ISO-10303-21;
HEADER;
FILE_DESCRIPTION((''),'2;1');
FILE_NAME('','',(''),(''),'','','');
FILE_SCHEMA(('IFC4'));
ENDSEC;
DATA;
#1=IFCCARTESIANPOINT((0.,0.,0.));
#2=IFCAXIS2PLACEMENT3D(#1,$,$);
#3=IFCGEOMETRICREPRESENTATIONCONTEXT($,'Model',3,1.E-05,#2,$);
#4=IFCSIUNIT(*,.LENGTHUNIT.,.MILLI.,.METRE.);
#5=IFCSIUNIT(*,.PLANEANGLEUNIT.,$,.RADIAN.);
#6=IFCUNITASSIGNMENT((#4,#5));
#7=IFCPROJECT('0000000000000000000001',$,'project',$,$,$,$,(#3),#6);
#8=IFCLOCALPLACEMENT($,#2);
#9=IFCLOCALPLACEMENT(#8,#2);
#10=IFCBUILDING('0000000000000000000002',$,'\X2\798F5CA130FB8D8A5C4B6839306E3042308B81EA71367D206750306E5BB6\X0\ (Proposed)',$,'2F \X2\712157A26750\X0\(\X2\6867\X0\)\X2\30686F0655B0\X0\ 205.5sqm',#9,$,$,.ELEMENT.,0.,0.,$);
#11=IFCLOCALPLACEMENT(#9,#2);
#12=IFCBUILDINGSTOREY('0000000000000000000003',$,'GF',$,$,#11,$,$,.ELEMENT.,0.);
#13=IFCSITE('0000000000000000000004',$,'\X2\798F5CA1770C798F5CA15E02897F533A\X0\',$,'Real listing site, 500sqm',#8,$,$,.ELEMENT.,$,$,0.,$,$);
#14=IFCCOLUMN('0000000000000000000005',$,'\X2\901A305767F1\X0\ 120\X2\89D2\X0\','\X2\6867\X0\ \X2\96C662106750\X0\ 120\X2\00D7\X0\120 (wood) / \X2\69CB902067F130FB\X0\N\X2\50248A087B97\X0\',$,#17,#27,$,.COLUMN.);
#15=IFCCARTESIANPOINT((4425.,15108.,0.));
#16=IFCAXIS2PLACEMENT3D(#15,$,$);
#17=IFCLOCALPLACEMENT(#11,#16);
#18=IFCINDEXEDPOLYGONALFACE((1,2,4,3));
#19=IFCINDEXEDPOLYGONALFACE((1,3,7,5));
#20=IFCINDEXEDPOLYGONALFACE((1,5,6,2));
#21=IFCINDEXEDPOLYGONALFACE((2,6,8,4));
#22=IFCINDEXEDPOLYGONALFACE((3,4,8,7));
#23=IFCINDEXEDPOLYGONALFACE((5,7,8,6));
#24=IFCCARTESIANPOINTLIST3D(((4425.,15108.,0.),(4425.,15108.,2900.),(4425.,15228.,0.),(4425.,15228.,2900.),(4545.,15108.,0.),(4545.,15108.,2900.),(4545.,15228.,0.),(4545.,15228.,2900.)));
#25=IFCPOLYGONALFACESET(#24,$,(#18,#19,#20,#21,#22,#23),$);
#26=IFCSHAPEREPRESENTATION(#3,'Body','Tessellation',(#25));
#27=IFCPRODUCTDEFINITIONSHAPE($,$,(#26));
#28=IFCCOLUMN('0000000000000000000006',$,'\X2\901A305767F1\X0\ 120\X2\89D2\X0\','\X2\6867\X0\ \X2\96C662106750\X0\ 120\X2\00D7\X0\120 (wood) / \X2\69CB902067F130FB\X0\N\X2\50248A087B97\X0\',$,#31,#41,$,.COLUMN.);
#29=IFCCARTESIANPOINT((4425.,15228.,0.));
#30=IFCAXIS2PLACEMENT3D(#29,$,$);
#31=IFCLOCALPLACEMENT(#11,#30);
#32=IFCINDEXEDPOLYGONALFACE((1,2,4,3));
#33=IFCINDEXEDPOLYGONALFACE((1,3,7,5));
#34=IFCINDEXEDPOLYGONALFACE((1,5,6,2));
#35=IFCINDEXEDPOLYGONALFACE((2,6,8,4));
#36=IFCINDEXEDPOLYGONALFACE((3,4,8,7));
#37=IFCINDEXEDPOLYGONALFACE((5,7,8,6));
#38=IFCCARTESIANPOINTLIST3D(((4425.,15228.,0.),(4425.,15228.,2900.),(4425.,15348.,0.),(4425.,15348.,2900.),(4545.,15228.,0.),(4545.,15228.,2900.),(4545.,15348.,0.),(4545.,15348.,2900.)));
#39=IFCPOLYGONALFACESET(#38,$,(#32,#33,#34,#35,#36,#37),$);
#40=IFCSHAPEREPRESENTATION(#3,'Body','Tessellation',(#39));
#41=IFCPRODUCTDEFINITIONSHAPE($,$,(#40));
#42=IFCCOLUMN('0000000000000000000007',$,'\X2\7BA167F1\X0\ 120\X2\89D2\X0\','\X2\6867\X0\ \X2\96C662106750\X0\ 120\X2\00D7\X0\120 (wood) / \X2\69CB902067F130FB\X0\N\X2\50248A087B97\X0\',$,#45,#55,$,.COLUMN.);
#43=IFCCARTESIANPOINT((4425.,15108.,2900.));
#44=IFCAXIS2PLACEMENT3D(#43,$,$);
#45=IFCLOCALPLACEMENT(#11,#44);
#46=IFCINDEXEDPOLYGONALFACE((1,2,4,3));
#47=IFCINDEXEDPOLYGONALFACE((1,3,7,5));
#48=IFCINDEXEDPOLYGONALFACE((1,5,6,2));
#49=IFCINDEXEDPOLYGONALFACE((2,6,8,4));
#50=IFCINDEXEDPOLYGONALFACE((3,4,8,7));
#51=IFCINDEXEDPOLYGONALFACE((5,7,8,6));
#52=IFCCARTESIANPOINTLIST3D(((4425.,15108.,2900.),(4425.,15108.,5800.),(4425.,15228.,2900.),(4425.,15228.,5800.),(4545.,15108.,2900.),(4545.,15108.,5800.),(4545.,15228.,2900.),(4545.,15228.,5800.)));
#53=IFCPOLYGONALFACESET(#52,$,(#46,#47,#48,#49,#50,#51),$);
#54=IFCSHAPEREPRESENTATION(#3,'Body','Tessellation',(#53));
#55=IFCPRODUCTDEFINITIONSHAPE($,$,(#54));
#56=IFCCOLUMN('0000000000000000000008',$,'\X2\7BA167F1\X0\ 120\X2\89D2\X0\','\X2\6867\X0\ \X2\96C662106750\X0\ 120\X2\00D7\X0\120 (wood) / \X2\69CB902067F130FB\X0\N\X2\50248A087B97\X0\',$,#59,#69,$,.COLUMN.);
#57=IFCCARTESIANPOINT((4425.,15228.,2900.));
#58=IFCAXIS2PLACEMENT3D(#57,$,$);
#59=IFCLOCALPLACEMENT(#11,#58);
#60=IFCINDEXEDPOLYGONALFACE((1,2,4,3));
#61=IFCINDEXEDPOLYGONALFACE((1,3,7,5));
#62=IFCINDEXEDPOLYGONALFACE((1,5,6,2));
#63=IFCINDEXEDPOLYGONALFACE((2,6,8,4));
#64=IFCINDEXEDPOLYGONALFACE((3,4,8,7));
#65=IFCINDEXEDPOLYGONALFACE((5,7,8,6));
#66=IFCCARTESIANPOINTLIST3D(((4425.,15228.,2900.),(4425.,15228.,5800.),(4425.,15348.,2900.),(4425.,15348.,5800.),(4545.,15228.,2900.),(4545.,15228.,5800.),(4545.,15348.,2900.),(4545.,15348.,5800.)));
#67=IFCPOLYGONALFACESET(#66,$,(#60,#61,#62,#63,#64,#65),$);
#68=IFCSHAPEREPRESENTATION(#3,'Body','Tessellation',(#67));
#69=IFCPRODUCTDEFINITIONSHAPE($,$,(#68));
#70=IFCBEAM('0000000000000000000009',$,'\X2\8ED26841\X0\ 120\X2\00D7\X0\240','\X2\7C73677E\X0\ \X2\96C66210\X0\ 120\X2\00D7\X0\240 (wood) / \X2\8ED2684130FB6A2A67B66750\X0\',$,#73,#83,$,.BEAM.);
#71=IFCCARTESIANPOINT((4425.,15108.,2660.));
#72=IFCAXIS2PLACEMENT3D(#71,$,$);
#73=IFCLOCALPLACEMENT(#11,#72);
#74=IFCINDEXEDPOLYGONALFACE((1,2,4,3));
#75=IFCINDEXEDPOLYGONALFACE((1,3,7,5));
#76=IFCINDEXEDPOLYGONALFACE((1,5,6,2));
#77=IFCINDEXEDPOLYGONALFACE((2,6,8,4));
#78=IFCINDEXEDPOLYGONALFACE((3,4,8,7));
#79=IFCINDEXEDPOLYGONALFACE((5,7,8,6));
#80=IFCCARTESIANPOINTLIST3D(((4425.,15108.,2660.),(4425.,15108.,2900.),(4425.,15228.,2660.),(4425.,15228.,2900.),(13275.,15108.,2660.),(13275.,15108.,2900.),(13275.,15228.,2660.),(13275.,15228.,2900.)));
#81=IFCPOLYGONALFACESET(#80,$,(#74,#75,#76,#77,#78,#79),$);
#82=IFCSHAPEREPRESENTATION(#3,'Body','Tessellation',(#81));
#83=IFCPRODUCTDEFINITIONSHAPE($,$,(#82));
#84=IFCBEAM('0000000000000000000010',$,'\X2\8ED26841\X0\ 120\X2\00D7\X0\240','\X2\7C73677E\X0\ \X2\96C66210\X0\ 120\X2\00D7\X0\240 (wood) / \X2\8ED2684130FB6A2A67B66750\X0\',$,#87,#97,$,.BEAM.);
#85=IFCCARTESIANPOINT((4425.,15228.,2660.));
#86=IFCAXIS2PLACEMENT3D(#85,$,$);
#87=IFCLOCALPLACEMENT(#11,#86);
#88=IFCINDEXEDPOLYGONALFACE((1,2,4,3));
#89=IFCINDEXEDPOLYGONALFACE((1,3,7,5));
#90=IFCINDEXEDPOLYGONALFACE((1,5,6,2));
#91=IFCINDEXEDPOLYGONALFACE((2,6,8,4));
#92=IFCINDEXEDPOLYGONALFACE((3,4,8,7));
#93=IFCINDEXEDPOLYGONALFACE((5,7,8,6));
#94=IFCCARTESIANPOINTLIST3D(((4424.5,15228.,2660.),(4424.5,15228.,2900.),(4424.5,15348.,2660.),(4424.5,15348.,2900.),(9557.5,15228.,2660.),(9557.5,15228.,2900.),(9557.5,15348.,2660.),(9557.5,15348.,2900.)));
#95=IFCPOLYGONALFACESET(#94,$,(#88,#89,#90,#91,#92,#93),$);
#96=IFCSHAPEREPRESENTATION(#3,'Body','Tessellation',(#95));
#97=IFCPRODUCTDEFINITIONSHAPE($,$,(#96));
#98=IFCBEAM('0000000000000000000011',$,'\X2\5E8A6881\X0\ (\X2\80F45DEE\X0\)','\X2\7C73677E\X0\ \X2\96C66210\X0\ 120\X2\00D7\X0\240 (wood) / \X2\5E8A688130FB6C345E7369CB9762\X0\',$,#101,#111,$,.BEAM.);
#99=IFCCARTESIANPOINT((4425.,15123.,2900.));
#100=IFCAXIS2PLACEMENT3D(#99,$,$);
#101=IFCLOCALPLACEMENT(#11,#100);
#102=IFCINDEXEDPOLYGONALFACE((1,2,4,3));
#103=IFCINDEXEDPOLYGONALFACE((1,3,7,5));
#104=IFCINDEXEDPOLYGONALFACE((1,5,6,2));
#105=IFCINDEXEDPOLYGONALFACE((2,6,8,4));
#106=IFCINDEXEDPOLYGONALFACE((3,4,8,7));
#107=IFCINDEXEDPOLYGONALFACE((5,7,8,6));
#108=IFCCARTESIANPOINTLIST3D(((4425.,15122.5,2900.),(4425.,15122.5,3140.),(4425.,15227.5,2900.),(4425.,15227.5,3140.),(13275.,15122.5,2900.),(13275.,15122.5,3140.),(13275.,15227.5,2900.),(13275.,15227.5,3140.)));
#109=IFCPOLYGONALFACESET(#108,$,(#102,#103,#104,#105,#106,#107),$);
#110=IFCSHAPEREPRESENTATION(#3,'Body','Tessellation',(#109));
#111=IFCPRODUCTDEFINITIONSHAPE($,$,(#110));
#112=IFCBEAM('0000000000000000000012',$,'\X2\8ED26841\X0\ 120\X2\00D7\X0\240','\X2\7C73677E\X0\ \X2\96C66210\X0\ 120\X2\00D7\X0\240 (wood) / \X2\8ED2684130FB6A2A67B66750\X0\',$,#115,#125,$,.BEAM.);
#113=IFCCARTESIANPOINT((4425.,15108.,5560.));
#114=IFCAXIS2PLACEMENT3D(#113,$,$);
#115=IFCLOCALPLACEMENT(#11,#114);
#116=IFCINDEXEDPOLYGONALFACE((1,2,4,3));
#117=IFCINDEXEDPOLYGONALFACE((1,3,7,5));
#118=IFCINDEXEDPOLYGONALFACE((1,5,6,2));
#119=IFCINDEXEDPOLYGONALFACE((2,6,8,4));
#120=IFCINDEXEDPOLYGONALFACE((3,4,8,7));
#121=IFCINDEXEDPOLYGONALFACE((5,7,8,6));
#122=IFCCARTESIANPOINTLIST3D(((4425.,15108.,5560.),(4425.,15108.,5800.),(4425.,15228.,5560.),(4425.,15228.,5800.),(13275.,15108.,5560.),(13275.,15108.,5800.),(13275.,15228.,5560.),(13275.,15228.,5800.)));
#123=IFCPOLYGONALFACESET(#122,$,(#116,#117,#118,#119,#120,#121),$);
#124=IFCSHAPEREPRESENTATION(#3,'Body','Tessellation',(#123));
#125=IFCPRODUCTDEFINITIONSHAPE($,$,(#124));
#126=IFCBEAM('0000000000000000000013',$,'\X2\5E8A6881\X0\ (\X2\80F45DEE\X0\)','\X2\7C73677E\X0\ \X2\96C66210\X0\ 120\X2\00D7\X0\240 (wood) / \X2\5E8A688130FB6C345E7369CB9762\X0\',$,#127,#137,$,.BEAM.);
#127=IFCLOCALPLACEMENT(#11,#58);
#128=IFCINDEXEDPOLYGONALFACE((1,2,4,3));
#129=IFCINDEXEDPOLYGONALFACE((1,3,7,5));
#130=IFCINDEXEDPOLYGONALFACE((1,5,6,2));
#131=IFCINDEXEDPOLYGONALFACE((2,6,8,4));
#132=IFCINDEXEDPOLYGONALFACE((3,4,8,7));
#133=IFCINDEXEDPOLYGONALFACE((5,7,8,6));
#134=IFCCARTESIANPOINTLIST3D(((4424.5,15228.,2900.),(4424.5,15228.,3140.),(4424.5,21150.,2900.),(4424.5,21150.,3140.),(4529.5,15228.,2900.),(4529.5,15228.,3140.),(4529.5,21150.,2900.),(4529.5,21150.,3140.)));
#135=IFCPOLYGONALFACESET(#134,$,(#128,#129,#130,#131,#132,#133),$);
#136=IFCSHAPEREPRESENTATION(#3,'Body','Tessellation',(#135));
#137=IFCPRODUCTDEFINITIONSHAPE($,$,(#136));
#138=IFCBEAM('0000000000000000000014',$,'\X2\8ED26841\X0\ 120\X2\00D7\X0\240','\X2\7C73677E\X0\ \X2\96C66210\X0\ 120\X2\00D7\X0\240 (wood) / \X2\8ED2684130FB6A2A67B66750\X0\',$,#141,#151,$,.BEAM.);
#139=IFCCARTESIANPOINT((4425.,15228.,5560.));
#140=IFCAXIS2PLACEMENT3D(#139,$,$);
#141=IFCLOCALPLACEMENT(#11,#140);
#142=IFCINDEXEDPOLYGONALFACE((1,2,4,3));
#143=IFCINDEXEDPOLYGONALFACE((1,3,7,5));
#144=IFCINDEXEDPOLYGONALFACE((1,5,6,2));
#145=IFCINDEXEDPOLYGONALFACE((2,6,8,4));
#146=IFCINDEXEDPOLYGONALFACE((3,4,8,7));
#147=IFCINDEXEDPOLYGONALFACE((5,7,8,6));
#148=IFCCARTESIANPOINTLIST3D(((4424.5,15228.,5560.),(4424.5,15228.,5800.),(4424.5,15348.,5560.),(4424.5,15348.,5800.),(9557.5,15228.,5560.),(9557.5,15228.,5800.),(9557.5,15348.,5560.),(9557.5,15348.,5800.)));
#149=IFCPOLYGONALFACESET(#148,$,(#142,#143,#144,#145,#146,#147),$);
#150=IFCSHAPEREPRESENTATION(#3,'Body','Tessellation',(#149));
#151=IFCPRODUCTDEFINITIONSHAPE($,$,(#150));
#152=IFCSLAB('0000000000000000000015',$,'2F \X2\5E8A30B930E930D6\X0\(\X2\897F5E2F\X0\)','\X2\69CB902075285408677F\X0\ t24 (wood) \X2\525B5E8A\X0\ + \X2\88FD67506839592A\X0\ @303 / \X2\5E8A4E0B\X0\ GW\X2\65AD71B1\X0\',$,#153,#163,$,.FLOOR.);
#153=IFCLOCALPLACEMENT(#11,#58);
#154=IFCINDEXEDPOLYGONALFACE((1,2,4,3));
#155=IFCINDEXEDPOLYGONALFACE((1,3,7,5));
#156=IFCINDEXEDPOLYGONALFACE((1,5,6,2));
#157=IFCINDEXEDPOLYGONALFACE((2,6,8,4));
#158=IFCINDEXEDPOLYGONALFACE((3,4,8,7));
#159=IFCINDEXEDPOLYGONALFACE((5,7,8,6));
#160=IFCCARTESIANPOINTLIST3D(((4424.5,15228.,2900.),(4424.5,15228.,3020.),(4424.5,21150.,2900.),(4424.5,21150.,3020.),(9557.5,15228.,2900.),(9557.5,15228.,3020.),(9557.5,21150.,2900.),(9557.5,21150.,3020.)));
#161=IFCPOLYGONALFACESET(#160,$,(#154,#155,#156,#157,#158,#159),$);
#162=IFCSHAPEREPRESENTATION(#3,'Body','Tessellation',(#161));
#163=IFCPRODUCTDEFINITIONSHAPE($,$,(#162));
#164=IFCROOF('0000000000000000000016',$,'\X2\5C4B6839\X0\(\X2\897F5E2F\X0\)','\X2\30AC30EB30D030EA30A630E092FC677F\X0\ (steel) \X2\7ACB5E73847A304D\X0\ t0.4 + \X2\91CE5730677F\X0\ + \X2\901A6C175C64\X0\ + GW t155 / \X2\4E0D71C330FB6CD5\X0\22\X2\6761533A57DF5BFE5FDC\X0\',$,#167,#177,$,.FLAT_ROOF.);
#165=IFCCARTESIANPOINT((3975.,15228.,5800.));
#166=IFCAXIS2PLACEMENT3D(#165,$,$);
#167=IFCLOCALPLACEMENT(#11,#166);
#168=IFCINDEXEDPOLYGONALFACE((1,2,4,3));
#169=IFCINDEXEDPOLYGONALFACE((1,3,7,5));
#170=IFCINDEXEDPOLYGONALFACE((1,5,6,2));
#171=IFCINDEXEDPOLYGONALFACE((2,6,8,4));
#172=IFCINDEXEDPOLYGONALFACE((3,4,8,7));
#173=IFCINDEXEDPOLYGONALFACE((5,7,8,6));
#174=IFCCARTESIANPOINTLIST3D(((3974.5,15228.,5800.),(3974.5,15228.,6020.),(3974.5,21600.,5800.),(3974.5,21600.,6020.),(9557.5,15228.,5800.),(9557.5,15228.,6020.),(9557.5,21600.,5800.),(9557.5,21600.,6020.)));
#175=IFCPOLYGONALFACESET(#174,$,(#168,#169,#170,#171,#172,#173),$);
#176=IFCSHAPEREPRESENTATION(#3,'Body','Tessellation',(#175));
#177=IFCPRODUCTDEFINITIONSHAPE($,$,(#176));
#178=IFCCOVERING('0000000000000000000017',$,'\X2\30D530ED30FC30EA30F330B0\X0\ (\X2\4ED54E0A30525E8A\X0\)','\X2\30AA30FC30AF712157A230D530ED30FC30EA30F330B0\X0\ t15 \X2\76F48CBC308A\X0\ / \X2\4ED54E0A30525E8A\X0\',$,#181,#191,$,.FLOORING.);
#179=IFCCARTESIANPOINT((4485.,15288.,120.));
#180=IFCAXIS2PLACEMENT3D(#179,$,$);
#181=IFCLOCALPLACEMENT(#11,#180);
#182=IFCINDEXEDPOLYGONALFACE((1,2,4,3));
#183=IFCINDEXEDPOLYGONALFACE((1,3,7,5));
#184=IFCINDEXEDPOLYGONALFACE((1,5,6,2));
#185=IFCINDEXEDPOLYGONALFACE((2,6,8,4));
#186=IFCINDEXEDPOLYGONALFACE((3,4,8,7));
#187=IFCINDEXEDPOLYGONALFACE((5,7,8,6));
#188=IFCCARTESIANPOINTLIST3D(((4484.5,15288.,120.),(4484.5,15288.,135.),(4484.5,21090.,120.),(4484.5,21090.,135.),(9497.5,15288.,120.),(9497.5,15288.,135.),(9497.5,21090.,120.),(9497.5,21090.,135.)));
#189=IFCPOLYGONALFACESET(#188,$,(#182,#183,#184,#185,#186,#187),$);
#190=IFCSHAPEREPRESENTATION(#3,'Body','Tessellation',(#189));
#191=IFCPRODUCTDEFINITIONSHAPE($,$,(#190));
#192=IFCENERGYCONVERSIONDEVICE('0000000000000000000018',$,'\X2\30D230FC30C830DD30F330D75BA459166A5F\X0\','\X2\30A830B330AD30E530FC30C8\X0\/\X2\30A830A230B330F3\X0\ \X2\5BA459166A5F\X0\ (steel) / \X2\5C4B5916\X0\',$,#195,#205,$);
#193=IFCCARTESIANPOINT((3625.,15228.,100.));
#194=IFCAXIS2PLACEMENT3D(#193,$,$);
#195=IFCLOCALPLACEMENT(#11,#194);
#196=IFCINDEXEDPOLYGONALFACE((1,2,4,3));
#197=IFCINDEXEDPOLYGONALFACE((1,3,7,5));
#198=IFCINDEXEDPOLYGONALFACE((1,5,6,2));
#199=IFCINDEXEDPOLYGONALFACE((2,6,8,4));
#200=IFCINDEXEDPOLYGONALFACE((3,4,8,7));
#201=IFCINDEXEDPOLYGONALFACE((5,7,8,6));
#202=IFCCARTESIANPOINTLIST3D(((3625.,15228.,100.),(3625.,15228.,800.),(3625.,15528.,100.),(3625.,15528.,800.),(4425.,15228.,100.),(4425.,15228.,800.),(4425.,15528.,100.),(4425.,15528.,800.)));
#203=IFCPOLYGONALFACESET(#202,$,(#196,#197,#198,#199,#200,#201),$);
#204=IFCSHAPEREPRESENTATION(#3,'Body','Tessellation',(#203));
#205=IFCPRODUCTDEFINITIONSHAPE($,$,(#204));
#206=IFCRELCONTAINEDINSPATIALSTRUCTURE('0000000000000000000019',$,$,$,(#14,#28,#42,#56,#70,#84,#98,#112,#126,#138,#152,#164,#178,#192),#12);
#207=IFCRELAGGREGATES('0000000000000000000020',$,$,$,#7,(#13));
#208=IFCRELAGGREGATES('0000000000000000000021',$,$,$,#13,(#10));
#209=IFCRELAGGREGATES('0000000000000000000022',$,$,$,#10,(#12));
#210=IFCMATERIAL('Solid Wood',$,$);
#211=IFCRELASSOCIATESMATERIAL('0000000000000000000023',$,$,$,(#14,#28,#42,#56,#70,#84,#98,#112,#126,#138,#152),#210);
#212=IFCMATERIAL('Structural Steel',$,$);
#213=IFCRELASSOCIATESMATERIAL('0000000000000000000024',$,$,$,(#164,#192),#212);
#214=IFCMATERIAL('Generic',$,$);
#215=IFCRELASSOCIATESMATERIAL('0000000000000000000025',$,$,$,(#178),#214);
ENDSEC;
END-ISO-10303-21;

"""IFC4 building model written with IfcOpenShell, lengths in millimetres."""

from ifc_helpers import new_model, si_unit, frame, frame_2d, origin, place, context, project, spatial, rectangle, extrude, material, element, save


model = new_model("IFC4")

# Units and contexts
model_context = context("Model", 3, precision=1e-05, world=origin())
ifc_project = project(units=[si_unit("LENGTHUNIT", "METRE", prefix="MILLI"), si_unit("PLANEANGLEUNIT", "RADIAN")], contexts=[model_context])

# Site, building, storey
site_placement = place(None, origin())
site = spatial("IfcSite", under=ifc_project, at=site_placement, Name="福岡県福岡市西区", ObjectType="Real listing site, 500sqm", CompositionType="ELEMENT", RefElevation=0.0)
building_placement = place(site_placement, origin())
building = spatial("IfcBuilding", under=site, at=building_placement, Name="福岡・越屋根のある自然素材の家 (Proposed)", ObjectType="2F 無垢材(桧)と漆喰 205.5sqm", CompositionType="ELEMENT", ElevationOfRefHeight=0.0, ElevationOfTerrain=0.0)
storey_placement = place(building_placement, origin())
storey = spatial("IfcBuildingStorey", under=building, at=storey_placement, Name="GF", CompositionType="ELEMENT", Elevation=0.0)

# Columns
ifc_material_1 = material(Name="Solid Wood")
column_1_placement = place(storey_placement, frame((4425.0, 15108.0, 0.0)))
element("IfcColumn", 1, at=column_1_placement, inside=storey, material=ifc_material_1, Name="通し柱 120角", Description="桧 集成材 120×120 (wood) / 構造柱・N値計算", PredefinedType="COLUMN", context=model_context, shape_type="SweptSolid", body=[
    extrude(rectangle(XDim=120.0, YDim=120.0, at=frame_2d((60.0, 60.0))), frame((4425.0, 15108.0, 0.0)), (0.0, 0.0, 1.0), 2900.0),
])
column_2_placement = place(storey_placement, frame((4425.0, 15228.0, 0.0)))
element("IfcColumn", 2, at=column_2_placement, inside=storey, material=ifc_material_1, Name="通し柱 120角", Description="桧 集成材 120×120 (wood) / 構造柱・N値計算", PredefinedType="COLUMN", context=model_context, shape_type="SweptSolid", body=[
    extrude(rectangle(XDim=120.0, YDim=120.0, at=frame_2d((60.0, 60.0))), frame((4425.0, 15228.0, 0.0)), (0.0, 0.0, 1.0), 2900.0),
])
column_3_placement = place(storey_placement, frame((4425.0, 15108.0, 2900.0)))
element("IfcColumn", 3, at=column_3_placement, inside=storey, material=ifc_material_1, Name="管柱 120角", Description="桧 集成材 120×120 (wood) / 構造柱・N値計算", PredefinedType="COLUMN", context=model_context, shape_type="SweptSolid", body=[
    extrude(rectangle(XDim=120.0, YDim=120.0, at=frame_2d((60.0, 60.0))), frame((4425.0, 15108.0, 2900.0)), (0.0, 0.0, 1.0), 2900.0),
])
column_4_placement = place(storey_placement, frame((4425.0, 15228.0, 2900.0)))
element("IfcColumn", 4, at=column_4_placement, inside=storey, material=ifc_material_1, Name="管柱 120角", Description="桧 集成材 120×120 (wood) / 構造柱・N値計算", PredefinedType="COLUMN", context=model_context, shape_type="SweptSolid", body=[
    extrude(rectangle(XDim=120.0, YDim=120.0, at=frame_2d((60.0, 60.0))), frame((4425.0, 15228.0, 2900.0)), (0.0, 0.0, 1.0), 2900.0),
])

# Beams
beam_1_placement = place(storey_placement, frame((4425.0, 15108.0, 2660.0)))
element("IfcBeam", 5, at=beam_1_placement, inside=storey, material=ifc_material_1, Name="軒桁 120×240", Description="米松 集成 120×240 (wood) / 軒桁・横架材", PredefinedType="BEAM", context=model_context, shape_type="SweptSolid", body=[
    extrude(rectangle(XDim=8850.0, YDim=120.0, at=frame_2d((4425.0, 60.0))), frame((4425.0, 15108.0, 2660.0)), (0.0, 0.0, 1.0), 240.0),
])
beam_2_placement = place(storey_placement, frame((4425.0, 15228.0, 2660.0)))
element("IfcBeam", 6, at=beam_2_placement, inside=storey, material=ifc_material_1, Name="軒桁 120×240", Description="米松 集成 120×240 (wood) / 軒桁・横架材", PredefinedType="BEAM", context=model_context, shape_type="SweptSolid", body=[
    extrude(rectangle(XDim=5133.0, YDim=120.0, at=frame_2d((2566.0, 60.0))), frame((4425.0, 15228.0, 2660.0)), (0.0, 0.0, 1.0), 240.0),
])
beam_3_placement = place(storey_placement, frame((4425.0, 15123.0, 2900.0)))
element("IfcBeam", 7, at=beam_3_placement, inside=storey, material=ifc_material_1, Name="床梁 (胴差)", Description="米松 集成 120×240 (wood) / 床梁・水平構面", PredefinedType="BEAM", context=model_context, shape_type="SweptSolid", body=[
    extrude(rectangle(XDim=8850.0, YDim=105.0, at=frame_2d((4425.0, 52.0))), frame((4425.0, 15123.0, 2900.0)), (0.0, 0.0, 1.0), 240.0),
])
beam_4_placement = place(storey_placement, frame((4425.0, 15108.0, 5560.0)))
element("IfcBeam", 8, at=beam_4_placement, inside=storey, material=ifc_material_1, Name="軒桁 120×240", Description="米松 集成 120×240 (wood) / 軒桁・横架材", PredefinedType="BEAM", context=model_context, shape_type="SweptSolid", body=[
    extrude(rectangle(XDim=8850.0, YDim=120.0, at=frame_2d((4425.0, 60.0))), frame((4425.0, 15108.0, 5560.0)), (0.0, 0.0, 1.0), 240.0),
])
beam_5_placement = place(storey_placement, frame((4425.0, 15228.0, 2900.0)))
element("IfcBeam", 9, at=beam_5_placement, inside=storey, material=ifc_material_1, Name="床梁 (胴差)", Description="米松 集成 120×240 (wood) / 床梁・水平構面", PredefinedType="BEAM", context=model_context, shape_type="SweptSolid", body=[
    extrude(rectangle(XDim=105.0, YDim=5922.0, at=frame_2d((52.0, 2961.0))), frame((4425.0, 15228.0, 2900.0)), (0.0, 0.0, 1.0), 240.0),
])
beam_6_placement = place(storey_placement, frame((4425.0, 15228.0, 5560.0)))
element("IfcBeam", 10, at=beam_6_placement, inside=storey, material=ifc_material_1, Name="軒桁 120×240", Description="米松 集成 120×240 (wood) / 軒桁・横架材", PredefinedType="BEAM", context=model_context, shape_type="SweptSolid", body=[
    extrude(rectangle(XDim=5133.0, YDim=120.0, at=frame_2d((2566.0, 60.0))), frame((4425.0, 15228.0, 5560.0)), (0.0, 0.0, 1.0), 240.0),
])

# Slab
slab_1_placement = place(storey_placement, frame((4425.0, 15228.0, 2900.0)))
element("IfcSlab", 11, at=slab_1_placement, inside=storey, material=ifc_material_1, Name="2F 床スラブ(西帯)", Description="構造用合板 t24 (wood) 剛床 + 製材根太 @303 / 床下 GW断熱", PredefinedType="FLOOR", context=model_context, shape_type="SweptSolid", body=[
    extrude(rectangle(XDim=5133.0, YDim=5922.0, at=frame_2d((2566.0, 2961.0))), frame((4425.0, 15228.0, 2900.0)), (0.0, 0.0, 1.0), 120.0),
])

# Roof
ifc_material_2 = material(Name="Structural Steel")
for number, where, name in (
    (12, (3975.0, 15228.0, 5800.0), "屋根(西帯)"),
):
    element("IfcRoof", number, at=place(storey_placement, frame(where)), inside=storey, material=ifc_material_2, Name=name, Description="ガルバリウム鋼板 (steel) 立平葺き t0.4 + 野地板 + 通気層 + GW t155 / 不燃・法22条区域対応", PredefinedType="FLAT_ROOF", context=model_context, shape_type="SweptSolid", body=[
        extrude(rectangle(XDim=5583.0, YDim=6372.0, at=frame_2d((2791.0, 3186.0))), frame((3975.0, 15228.0, 5800.0)), (0.0, 0.0, 1.0), 220.0),
    ])

# Covering
ifc_material_3 = material(Name="Generic")
covering_placement = place(storey_placement, frame((4485.0, 15288.0, 120.0)))
element("IfcCovering", 13, at=covering_placement, inside=storey, material=ifc_material_3, Name="フローリング (仕上げ床)", Description="オーク無垢フローリング t15 直貼り / 仕上げ床", PredefinedType="FLOORING", context=model_context, shape_type="SweptSolid", body=[
    extrude(rectangle(XDim=5013.0, YDim=5802.0, at=frame_2d((2506.0, 2901.0))), frame((4485.0, 15288.0, 120.0)), (0.0, 0.0, 1.0), 15.0),
])

# Energy conversion device
energy_conversion_device_placement = place(storey_placement, frame((3625.0, 15228.0, 100.0)))
element("IfcEnergyConversionDevice", 14, at=energy_conversion_device_placement, inside=storey, material=ifc_material_2, Name="ヒートポンプ室外機", Description="エコキュート/エアコン 室外機 (steel) / 屋外", context=model_context, shape_type="SweptSolid", body=[
    extrude(rectangle(XDim=800.0, YDim=300.0, at=frame_2d((400.0, 150.0))), frame((3625.0, 15228.0, 100.0)), (0.0, 0.0, 1.0), 700.0),
])

save(model, "model.ifc")
